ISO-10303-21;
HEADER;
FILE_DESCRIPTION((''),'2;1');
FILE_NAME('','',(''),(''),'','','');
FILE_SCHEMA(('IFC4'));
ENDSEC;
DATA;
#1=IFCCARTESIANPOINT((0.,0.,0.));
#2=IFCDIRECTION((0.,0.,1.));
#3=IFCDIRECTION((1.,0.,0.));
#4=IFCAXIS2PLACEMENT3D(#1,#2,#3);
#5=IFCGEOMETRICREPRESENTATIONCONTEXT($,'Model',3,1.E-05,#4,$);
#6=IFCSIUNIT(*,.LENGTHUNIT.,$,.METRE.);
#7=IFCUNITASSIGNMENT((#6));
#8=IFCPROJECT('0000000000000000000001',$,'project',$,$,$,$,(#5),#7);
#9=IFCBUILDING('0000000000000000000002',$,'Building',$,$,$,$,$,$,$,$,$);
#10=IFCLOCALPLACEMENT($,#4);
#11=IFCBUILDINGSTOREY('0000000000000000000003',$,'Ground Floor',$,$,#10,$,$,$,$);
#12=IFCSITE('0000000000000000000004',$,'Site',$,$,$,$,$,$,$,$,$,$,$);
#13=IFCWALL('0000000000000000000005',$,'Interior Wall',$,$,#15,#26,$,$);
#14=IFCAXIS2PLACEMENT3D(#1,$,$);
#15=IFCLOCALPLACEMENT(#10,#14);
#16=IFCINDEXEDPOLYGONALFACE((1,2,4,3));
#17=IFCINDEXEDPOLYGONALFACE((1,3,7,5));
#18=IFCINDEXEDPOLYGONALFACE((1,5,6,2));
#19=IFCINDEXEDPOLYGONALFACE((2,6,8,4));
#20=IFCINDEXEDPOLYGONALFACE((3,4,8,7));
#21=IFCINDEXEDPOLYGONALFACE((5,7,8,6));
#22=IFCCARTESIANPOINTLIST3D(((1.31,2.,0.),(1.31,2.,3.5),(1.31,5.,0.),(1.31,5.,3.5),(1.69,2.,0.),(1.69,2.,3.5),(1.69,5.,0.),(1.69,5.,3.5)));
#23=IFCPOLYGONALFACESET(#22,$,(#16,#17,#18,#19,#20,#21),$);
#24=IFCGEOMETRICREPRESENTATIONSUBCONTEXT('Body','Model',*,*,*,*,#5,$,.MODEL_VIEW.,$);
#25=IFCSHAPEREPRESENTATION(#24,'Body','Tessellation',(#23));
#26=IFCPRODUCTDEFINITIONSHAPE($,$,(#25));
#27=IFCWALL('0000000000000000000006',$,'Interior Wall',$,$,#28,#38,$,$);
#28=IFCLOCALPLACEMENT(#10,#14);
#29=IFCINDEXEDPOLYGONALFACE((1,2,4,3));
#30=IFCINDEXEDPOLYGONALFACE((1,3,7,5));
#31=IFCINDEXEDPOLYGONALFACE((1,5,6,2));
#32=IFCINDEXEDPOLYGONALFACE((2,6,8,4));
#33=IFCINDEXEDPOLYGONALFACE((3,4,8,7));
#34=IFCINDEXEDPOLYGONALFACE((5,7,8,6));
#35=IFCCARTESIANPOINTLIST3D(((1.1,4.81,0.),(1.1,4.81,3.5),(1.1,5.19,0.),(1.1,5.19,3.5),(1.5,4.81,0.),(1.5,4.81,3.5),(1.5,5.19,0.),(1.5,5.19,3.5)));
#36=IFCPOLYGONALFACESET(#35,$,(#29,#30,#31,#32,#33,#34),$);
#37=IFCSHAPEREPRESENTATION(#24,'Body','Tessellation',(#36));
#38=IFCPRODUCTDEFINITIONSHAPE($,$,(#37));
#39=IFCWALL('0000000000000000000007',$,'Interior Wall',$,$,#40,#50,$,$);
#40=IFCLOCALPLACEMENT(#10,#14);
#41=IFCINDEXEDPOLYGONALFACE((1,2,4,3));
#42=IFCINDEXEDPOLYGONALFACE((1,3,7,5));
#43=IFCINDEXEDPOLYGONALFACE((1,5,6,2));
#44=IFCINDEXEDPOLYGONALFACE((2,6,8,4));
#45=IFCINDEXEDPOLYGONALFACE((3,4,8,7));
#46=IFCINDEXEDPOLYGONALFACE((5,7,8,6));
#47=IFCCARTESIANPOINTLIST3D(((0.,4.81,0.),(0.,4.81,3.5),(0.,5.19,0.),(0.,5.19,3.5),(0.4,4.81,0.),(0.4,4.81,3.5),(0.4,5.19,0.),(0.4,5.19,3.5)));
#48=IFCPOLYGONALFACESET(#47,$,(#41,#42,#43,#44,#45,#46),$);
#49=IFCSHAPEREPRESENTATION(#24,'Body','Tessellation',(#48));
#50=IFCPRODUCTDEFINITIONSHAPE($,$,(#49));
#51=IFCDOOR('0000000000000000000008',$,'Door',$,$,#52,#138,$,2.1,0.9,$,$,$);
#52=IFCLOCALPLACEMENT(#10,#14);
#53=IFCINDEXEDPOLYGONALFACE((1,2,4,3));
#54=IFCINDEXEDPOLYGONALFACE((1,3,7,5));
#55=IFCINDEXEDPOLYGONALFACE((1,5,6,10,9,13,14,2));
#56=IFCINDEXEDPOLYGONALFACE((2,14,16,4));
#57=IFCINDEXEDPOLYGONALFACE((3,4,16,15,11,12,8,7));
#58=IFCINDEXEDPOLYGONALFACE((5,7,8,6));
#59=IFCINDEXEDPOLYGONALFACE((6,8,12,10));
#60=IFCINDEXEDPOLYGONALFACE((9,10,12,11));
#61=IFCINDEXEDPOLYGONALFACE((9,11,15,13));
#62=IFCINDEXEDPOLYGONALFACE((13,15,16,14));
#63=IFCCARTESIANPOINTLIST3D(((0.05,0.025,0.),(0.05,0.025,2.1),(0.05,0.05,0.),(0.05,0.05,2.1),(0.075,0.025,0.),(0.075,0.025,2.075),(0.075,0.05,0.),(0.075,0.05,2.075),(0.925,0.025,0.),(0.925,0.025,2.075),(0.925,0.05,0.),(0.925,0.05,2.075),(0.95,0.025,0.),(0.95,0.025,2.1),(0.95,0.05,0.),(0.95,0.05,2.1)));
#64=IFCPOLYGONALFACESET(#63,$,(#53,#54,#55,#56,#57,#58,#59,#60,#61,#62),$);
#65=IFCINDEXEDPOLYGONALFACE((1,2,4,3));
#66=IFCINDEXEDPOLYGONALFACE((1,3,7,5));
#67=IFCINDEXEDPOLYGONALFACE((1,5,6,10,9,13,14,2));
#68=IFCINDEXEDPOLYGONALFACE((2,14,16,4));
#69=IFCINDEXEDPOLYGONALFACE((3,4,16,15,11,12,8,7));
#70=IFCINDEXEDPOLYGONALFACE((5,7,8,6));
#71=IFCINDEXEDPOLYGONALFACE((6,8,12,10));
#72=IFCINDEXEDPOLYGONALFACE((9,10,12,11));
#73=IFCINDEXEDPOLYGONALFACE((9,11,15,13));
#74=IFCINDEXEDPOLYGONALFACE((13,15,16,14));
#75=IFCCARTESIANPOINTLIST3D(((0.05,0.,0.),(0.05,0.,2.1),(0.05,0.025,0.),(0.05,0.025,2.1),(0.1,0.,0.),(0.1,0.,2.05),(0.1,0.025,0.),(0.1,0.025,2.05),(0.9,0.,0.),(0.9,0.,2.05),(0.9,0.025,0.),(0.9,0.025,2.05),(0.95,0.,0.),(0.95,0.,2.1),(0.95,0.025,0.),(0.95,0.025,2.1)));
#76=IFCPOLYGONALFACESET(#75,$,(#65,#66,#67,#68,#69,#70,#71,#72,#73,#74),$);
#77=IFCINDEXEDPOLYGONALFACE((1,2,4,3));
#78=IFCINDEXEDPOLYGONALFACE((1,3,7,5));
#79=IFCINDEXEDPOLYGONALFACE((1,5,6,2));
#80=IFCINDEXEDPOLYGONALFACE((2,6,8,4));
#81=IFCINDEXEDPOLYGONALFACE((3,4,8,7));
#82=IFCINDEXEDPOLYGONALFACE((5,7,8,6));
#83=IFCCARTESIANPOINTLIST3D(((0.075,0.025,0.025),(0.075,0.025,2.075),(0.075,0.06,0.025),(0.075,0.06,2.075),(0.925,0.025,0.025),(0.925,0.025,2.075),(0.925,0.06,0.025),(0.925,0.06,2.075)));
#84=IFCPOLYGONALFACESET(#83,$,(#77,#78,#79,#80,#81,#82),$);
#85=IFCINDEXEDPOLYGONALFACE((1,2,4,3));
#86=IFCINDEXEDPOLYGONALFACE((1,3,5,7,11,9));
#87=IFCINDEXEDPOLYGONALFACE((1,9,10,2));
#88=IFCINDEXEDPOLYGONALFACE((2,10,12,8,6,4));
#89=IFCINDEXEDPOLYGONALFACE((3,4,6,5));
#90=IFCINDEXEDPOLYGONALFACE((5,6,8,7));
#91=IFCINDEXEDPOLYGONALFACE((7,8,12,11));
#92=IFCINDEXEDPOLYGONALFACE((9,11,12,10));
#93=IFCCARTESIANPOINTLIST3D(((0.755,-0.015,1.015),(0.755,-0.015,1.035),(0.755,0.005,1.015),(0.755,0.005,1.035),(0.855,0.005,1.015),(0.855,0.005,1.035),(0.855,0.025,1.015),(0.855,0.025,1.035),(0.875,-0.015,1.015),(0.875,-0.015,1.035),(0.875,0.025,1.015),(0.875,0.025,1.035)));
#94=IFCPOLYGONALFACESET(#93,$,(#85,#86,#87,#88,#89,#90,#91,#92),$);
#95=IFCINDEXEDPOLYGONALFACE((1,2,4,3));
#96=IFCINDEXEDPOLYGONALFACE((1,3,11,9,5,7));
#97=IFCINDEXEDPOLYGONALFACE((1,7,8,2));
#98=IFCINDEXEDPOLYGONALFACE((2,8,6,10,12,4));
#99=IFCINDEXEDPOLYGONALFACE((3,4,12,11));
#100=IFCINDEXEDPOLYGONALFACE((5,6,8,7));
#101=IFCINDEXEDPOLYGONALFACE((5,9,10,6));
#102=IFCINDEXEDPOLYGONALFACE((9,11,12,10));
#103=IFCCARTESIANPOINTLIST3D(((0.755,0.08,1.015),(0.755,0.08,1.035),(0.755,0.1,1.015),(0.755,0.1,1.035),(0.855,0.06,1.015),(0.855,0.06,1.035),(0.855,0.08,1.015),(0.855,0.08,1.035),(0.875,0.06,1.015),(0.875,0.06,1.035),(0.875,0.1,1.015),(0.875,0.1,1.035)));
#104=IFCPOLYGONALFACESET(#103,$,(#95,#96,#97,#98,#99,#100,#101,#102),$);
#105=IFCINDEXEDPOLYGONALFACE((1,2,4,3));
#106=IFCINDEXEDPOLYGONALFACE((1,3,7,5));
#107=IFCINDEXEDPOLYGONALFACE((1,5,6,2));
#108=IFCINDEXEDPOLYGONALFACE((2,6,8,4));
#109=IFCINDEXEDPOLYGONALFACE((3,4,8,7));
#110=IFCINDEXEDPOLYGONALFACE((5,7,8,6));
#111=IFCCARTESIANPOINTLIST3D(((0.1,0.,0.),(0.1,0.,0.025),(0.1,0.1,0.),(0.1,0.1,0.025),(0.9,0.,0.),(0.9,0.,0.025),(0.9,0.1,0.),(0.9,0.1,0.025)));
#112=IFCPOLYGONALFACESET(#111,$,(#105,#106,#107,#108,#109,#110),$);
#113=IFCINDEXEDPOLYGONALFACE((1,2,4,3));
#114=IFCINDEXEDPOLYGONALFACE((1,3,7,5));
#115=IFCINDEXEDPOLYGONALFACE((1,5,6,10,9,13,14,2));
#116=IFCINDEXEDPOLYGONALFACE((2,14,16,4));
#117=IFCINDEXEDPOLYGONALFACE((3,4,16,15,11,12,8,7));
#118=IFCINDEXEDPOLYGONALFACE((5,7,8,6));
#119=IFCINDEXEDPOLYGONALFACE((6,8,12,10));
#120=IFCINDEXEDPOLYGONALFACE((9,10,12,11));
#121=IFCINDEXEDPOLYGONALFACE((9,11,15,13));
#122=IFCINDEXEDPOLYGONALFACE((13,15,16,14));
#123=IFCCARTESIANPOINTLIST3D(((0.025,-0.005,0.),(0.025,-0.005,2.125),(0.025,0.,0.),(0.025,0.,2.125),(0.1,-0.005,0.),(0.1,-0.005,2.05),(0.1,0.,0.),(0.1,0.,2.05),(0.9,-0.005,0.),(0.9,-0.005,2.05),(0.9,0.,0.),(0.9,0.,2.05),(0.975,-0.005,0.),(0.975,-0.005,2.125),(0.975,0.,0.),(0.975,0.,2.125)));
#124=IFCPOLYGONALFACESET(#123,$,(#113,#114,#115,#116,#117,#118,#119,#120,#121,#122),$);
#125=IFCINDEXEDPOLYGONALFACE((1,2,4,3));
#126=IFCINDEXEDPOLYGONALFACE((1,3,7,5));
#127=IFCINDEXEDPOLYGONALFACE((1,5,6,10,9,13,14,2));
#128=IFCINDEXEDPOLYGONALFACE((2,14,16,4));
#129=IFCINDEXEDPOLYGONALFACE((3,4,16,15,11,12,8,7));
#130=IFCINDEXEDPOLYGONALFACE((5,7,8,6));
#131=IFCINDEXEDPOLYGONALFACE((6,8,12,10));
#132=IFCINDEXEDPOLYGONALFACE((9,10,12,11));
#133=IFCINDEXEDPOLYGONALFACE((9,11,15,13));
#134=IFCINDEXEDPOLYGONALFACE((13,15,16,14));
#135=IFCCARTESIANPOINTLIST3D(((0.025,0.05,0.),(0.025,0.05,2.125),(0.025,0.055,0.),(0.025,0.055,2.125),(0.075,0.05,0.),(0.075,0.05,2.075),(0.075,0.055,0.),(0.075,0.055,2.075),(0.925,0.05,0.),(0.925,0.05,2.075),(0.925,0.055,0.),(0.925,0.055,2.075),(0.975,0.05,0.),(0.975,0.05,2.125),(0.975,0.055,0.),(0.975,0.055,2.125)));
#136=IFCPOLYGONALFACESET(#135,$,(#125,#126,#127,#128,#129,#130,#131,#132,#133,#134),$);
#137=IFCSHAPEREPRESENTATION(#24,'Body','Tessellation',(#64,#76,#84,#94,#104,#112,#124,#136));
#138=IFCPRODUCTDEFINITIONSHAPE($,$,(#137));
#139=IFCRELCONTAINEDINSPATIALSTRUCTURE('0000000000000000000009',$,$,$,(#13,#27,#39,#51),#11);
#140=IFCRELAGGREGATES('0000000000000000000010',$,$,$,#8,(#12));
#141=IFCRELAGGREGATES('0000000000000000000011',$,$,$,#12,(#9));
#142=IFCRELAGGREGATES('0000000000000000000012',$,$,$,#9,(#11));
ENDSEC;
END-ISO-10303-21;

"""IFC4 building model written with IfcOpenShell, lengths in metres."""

from ifc_helpers import new_model, si_unit, frame, origin_with_axes, place, context, subcontext, project, spatial, line, indexed_curve, outline, extrude, element, save


model = new_model("IFC4")

# Units and contexts
model_context = context("Model", 3, precision=1e-05, world=origin_with_axes())
body_context = subcontext(model_context, "Body", "Model", "MODEL_VIEW")
ifc_project = project(units=[si_unit("LENGTHUNIT", "METRE")], contexts=[model_context])

# Site, building, storey
site = spatial("IfcSite", under=ifc_project, Name="Site")
building = spatial("IfcBuilding", under=site, Name="Building")
storey_placement = place(None, origin_with_axes())
storey = spatial("IfcBuildingStorey", under=building, at=storey_placement, Name="Ground Floor")

# Walls
wall_1_placement = place(storey_placement, frame((1.5, 5.0, 0.0), z_axis=(0.0, 0.0, 1.0), x_axis=(0.0, -1.0, 0.0)))
element("IfcWall", 1, at=wall_1_placement, inside=storey, Name="Interior Wall", context=body_context, shape_type="SweptSolid", body=[
    extrude(outline(indexed_curve([(0.0, 0.0), (0.0, 0.38), (3.0, 0.38), (3.0, 0.0), (0.0, 0.0)], self_intersect=False)), frame((0.0, -0.19, 0.0), z_axis=(0.0, 0.0, 1.0), x_axis=(1.0, 0.0, 0.0)), (0.0, 0.0, 1.0), 3.5),
])
for number, where, z_axis, x_axis, name in (
    (2, (1.5, 5.0, 0.0), (0.0, 0.0, 1.0), (-1.0, 0.0, 0.0), "Interior Wall"),
    (3, (0.4, 5.0, 0.0), (0.0, 0.0, 1.0), (-1.0, 0.0, 0.0), "Interior Wall"),
):
    element("IfcWall", number, at=place(storey_placement, frame(where, z_axis=z_axis, x_axis=x_axis)), inside=storey, Name=name, context=body_context, shape_type="SweptSolid", body=[
        extrude(outline(indexed_curve([(0.0, 0.0), (0.0, 0.38), (0.4, 0.38), (0.4, 0.0), (0.0, 0.0)], self_intersect=False)), frame((0.0, -0.19, 0.0), z_axis=(0.0, 0.0, 1.0), x_axis=(1.0, 0.0, 0.0)), (0.0, 0.0, 1.0), 3.5),
    ])

# Door
door_1_placement = place(storey_placement, frame((0.05, 0.0, 0.0), z_axis=(0.0, 0.0, 1.0), x_axis=(1.0, 0.0, 0.0)))
element("IfcDoor", 4, at=door_1_placement, inside=storey, Name="Door", OverallHeight=2.1, OverallWidth=0.9, context=body_context, shape_type="SweptSolid", body=[
    extrude(outline(indexed_curve([(0.0, 0.0), (0.0, 2.1), (0.9, 2.1), (0.9, 0.0), (0.875, 0.0), (0.875, 2.075), (0.025, 2.075), (0.025, 0.0)], segments=[line(1, 2, 3, 4, 5, 6, 7, 8, 1)])), frame((0.0, 0.025, 0.0), z_axis=(0.0, -1.0, 0.0), x_axis=(1.0, 0.0, 0.0)), (0.0, 0.0, -1.0), 0.025),
    extrude(outline(indexed_curve([(0.0, 0.0), (0.0, 2.1), (0.9, 2.1), (0.9, 0.0), (0.85, 0.0), (0.85, 2.05), (0.05, 2.05), (0.05, 0.0)], segments=[line(1, 2, 3, 4, 5, 6, 7, 8, 1)])), frame((0.0, 0.0, 0.0), z_axis=(0.0, -1.0, 0.0), x_axis=(1.0, 0.0, 0.0)), (0.0, 0.0, -1.0), 0.025),
    extrude(outline(indexed_curve([(0.0, 0.0), (0.85, 0.0), (0.85, 0.035), (0.0, 0.035)], segments=[line(1, 2, 3, 4, 1)])), frame((0.025, 0.025, 0.025), z_axis=(0.0, 0.0, 1.0), x_axis=(1.0, 0.0, 0.0)), (0.0, 0.0, 1.0), 2.05),
    extrude(outline(indexed_curve([(0.0, 0.0), (0.0, -0.04), (-0.12, -0.04), (-0.12, -0.02), (-0.02, -0.02), (-0.02, 0.0)], segments=[line(1, 2, 3, 4, 5, 6, 1)])), frame((0.825, 0.025, 1.015), z_axis=(0.0, 0.0, 1.0), x_axis=(1.0, 0.0, 0.0)), (0.0, 0.0, 1.0), 0.02),
    extrude(outline(indexed_curve([(0.0, 0.0), (0.0, 0.04), (-0.12, 0.04), (-0.12, 0.02), (-0.02, 0.02), (-0.02, 0.0)], segments=[line(1, 2, 3, 4, 5, 6, 1)])), frame((0.825, 0.06, 1.015), z_axis=(0.0, 0.0, 1.0), x_axis=(1.0, 0.0, 0.0)), (0.0, 0.0, 1.0), 0.02),
    extrude(outline(indexed_curve([(0.0, 0.0), (0.8, 0.0), (0.8, 0.1), (0.0, 0.1)], segments=[line(1, 2, 3, 4, 1)])), frame((0.05, 0.0, 0.0), z_axis=(0.0, 0.0, 1.0), x_axis=(1.0, 0.0, 0.0)), (0.0, 0.0, 1.0), 0.025),
    extrude(outline(indexed_curve([(0.0, 0.0), (0.0, 2.125), (0.95, 2.125), (0.95, 0.0), (0.875, 0.0), (0.875, 2.05), (0.075, 2.05), (0.075, 0.0)], segments=[line(1, 2, 3, 4, 5, 6, 7, 8, 1)])), frame((-0.025, -0.005, 0.0), z_axis=(0.0, -1.0, 0.0), x_axis=(1.0, 0.0, 0.0)), (0.0, 0.0, -1.0), 0.005),
    extrude(outline(indexed_curve([(0.0, 0.0), (0.0, 2.125), (0.95, 2.125), (0.95, 0.0), (0.9, 0.0), (0.9, 2.075), (0.05, 2.075), (0.05, 0.0)], segments=[line(1, 2, 3, 4, 5, 6, 7, 8, 1)])), frame((-0.025, 0.05, 0.0), z_axis=(0.0, -1.0, 0.0), x_axis=(1.0, 0.0, 0.0)), (0.0, 0.0, -1.0), 0.005),
])

save(model, "model.ifc")
